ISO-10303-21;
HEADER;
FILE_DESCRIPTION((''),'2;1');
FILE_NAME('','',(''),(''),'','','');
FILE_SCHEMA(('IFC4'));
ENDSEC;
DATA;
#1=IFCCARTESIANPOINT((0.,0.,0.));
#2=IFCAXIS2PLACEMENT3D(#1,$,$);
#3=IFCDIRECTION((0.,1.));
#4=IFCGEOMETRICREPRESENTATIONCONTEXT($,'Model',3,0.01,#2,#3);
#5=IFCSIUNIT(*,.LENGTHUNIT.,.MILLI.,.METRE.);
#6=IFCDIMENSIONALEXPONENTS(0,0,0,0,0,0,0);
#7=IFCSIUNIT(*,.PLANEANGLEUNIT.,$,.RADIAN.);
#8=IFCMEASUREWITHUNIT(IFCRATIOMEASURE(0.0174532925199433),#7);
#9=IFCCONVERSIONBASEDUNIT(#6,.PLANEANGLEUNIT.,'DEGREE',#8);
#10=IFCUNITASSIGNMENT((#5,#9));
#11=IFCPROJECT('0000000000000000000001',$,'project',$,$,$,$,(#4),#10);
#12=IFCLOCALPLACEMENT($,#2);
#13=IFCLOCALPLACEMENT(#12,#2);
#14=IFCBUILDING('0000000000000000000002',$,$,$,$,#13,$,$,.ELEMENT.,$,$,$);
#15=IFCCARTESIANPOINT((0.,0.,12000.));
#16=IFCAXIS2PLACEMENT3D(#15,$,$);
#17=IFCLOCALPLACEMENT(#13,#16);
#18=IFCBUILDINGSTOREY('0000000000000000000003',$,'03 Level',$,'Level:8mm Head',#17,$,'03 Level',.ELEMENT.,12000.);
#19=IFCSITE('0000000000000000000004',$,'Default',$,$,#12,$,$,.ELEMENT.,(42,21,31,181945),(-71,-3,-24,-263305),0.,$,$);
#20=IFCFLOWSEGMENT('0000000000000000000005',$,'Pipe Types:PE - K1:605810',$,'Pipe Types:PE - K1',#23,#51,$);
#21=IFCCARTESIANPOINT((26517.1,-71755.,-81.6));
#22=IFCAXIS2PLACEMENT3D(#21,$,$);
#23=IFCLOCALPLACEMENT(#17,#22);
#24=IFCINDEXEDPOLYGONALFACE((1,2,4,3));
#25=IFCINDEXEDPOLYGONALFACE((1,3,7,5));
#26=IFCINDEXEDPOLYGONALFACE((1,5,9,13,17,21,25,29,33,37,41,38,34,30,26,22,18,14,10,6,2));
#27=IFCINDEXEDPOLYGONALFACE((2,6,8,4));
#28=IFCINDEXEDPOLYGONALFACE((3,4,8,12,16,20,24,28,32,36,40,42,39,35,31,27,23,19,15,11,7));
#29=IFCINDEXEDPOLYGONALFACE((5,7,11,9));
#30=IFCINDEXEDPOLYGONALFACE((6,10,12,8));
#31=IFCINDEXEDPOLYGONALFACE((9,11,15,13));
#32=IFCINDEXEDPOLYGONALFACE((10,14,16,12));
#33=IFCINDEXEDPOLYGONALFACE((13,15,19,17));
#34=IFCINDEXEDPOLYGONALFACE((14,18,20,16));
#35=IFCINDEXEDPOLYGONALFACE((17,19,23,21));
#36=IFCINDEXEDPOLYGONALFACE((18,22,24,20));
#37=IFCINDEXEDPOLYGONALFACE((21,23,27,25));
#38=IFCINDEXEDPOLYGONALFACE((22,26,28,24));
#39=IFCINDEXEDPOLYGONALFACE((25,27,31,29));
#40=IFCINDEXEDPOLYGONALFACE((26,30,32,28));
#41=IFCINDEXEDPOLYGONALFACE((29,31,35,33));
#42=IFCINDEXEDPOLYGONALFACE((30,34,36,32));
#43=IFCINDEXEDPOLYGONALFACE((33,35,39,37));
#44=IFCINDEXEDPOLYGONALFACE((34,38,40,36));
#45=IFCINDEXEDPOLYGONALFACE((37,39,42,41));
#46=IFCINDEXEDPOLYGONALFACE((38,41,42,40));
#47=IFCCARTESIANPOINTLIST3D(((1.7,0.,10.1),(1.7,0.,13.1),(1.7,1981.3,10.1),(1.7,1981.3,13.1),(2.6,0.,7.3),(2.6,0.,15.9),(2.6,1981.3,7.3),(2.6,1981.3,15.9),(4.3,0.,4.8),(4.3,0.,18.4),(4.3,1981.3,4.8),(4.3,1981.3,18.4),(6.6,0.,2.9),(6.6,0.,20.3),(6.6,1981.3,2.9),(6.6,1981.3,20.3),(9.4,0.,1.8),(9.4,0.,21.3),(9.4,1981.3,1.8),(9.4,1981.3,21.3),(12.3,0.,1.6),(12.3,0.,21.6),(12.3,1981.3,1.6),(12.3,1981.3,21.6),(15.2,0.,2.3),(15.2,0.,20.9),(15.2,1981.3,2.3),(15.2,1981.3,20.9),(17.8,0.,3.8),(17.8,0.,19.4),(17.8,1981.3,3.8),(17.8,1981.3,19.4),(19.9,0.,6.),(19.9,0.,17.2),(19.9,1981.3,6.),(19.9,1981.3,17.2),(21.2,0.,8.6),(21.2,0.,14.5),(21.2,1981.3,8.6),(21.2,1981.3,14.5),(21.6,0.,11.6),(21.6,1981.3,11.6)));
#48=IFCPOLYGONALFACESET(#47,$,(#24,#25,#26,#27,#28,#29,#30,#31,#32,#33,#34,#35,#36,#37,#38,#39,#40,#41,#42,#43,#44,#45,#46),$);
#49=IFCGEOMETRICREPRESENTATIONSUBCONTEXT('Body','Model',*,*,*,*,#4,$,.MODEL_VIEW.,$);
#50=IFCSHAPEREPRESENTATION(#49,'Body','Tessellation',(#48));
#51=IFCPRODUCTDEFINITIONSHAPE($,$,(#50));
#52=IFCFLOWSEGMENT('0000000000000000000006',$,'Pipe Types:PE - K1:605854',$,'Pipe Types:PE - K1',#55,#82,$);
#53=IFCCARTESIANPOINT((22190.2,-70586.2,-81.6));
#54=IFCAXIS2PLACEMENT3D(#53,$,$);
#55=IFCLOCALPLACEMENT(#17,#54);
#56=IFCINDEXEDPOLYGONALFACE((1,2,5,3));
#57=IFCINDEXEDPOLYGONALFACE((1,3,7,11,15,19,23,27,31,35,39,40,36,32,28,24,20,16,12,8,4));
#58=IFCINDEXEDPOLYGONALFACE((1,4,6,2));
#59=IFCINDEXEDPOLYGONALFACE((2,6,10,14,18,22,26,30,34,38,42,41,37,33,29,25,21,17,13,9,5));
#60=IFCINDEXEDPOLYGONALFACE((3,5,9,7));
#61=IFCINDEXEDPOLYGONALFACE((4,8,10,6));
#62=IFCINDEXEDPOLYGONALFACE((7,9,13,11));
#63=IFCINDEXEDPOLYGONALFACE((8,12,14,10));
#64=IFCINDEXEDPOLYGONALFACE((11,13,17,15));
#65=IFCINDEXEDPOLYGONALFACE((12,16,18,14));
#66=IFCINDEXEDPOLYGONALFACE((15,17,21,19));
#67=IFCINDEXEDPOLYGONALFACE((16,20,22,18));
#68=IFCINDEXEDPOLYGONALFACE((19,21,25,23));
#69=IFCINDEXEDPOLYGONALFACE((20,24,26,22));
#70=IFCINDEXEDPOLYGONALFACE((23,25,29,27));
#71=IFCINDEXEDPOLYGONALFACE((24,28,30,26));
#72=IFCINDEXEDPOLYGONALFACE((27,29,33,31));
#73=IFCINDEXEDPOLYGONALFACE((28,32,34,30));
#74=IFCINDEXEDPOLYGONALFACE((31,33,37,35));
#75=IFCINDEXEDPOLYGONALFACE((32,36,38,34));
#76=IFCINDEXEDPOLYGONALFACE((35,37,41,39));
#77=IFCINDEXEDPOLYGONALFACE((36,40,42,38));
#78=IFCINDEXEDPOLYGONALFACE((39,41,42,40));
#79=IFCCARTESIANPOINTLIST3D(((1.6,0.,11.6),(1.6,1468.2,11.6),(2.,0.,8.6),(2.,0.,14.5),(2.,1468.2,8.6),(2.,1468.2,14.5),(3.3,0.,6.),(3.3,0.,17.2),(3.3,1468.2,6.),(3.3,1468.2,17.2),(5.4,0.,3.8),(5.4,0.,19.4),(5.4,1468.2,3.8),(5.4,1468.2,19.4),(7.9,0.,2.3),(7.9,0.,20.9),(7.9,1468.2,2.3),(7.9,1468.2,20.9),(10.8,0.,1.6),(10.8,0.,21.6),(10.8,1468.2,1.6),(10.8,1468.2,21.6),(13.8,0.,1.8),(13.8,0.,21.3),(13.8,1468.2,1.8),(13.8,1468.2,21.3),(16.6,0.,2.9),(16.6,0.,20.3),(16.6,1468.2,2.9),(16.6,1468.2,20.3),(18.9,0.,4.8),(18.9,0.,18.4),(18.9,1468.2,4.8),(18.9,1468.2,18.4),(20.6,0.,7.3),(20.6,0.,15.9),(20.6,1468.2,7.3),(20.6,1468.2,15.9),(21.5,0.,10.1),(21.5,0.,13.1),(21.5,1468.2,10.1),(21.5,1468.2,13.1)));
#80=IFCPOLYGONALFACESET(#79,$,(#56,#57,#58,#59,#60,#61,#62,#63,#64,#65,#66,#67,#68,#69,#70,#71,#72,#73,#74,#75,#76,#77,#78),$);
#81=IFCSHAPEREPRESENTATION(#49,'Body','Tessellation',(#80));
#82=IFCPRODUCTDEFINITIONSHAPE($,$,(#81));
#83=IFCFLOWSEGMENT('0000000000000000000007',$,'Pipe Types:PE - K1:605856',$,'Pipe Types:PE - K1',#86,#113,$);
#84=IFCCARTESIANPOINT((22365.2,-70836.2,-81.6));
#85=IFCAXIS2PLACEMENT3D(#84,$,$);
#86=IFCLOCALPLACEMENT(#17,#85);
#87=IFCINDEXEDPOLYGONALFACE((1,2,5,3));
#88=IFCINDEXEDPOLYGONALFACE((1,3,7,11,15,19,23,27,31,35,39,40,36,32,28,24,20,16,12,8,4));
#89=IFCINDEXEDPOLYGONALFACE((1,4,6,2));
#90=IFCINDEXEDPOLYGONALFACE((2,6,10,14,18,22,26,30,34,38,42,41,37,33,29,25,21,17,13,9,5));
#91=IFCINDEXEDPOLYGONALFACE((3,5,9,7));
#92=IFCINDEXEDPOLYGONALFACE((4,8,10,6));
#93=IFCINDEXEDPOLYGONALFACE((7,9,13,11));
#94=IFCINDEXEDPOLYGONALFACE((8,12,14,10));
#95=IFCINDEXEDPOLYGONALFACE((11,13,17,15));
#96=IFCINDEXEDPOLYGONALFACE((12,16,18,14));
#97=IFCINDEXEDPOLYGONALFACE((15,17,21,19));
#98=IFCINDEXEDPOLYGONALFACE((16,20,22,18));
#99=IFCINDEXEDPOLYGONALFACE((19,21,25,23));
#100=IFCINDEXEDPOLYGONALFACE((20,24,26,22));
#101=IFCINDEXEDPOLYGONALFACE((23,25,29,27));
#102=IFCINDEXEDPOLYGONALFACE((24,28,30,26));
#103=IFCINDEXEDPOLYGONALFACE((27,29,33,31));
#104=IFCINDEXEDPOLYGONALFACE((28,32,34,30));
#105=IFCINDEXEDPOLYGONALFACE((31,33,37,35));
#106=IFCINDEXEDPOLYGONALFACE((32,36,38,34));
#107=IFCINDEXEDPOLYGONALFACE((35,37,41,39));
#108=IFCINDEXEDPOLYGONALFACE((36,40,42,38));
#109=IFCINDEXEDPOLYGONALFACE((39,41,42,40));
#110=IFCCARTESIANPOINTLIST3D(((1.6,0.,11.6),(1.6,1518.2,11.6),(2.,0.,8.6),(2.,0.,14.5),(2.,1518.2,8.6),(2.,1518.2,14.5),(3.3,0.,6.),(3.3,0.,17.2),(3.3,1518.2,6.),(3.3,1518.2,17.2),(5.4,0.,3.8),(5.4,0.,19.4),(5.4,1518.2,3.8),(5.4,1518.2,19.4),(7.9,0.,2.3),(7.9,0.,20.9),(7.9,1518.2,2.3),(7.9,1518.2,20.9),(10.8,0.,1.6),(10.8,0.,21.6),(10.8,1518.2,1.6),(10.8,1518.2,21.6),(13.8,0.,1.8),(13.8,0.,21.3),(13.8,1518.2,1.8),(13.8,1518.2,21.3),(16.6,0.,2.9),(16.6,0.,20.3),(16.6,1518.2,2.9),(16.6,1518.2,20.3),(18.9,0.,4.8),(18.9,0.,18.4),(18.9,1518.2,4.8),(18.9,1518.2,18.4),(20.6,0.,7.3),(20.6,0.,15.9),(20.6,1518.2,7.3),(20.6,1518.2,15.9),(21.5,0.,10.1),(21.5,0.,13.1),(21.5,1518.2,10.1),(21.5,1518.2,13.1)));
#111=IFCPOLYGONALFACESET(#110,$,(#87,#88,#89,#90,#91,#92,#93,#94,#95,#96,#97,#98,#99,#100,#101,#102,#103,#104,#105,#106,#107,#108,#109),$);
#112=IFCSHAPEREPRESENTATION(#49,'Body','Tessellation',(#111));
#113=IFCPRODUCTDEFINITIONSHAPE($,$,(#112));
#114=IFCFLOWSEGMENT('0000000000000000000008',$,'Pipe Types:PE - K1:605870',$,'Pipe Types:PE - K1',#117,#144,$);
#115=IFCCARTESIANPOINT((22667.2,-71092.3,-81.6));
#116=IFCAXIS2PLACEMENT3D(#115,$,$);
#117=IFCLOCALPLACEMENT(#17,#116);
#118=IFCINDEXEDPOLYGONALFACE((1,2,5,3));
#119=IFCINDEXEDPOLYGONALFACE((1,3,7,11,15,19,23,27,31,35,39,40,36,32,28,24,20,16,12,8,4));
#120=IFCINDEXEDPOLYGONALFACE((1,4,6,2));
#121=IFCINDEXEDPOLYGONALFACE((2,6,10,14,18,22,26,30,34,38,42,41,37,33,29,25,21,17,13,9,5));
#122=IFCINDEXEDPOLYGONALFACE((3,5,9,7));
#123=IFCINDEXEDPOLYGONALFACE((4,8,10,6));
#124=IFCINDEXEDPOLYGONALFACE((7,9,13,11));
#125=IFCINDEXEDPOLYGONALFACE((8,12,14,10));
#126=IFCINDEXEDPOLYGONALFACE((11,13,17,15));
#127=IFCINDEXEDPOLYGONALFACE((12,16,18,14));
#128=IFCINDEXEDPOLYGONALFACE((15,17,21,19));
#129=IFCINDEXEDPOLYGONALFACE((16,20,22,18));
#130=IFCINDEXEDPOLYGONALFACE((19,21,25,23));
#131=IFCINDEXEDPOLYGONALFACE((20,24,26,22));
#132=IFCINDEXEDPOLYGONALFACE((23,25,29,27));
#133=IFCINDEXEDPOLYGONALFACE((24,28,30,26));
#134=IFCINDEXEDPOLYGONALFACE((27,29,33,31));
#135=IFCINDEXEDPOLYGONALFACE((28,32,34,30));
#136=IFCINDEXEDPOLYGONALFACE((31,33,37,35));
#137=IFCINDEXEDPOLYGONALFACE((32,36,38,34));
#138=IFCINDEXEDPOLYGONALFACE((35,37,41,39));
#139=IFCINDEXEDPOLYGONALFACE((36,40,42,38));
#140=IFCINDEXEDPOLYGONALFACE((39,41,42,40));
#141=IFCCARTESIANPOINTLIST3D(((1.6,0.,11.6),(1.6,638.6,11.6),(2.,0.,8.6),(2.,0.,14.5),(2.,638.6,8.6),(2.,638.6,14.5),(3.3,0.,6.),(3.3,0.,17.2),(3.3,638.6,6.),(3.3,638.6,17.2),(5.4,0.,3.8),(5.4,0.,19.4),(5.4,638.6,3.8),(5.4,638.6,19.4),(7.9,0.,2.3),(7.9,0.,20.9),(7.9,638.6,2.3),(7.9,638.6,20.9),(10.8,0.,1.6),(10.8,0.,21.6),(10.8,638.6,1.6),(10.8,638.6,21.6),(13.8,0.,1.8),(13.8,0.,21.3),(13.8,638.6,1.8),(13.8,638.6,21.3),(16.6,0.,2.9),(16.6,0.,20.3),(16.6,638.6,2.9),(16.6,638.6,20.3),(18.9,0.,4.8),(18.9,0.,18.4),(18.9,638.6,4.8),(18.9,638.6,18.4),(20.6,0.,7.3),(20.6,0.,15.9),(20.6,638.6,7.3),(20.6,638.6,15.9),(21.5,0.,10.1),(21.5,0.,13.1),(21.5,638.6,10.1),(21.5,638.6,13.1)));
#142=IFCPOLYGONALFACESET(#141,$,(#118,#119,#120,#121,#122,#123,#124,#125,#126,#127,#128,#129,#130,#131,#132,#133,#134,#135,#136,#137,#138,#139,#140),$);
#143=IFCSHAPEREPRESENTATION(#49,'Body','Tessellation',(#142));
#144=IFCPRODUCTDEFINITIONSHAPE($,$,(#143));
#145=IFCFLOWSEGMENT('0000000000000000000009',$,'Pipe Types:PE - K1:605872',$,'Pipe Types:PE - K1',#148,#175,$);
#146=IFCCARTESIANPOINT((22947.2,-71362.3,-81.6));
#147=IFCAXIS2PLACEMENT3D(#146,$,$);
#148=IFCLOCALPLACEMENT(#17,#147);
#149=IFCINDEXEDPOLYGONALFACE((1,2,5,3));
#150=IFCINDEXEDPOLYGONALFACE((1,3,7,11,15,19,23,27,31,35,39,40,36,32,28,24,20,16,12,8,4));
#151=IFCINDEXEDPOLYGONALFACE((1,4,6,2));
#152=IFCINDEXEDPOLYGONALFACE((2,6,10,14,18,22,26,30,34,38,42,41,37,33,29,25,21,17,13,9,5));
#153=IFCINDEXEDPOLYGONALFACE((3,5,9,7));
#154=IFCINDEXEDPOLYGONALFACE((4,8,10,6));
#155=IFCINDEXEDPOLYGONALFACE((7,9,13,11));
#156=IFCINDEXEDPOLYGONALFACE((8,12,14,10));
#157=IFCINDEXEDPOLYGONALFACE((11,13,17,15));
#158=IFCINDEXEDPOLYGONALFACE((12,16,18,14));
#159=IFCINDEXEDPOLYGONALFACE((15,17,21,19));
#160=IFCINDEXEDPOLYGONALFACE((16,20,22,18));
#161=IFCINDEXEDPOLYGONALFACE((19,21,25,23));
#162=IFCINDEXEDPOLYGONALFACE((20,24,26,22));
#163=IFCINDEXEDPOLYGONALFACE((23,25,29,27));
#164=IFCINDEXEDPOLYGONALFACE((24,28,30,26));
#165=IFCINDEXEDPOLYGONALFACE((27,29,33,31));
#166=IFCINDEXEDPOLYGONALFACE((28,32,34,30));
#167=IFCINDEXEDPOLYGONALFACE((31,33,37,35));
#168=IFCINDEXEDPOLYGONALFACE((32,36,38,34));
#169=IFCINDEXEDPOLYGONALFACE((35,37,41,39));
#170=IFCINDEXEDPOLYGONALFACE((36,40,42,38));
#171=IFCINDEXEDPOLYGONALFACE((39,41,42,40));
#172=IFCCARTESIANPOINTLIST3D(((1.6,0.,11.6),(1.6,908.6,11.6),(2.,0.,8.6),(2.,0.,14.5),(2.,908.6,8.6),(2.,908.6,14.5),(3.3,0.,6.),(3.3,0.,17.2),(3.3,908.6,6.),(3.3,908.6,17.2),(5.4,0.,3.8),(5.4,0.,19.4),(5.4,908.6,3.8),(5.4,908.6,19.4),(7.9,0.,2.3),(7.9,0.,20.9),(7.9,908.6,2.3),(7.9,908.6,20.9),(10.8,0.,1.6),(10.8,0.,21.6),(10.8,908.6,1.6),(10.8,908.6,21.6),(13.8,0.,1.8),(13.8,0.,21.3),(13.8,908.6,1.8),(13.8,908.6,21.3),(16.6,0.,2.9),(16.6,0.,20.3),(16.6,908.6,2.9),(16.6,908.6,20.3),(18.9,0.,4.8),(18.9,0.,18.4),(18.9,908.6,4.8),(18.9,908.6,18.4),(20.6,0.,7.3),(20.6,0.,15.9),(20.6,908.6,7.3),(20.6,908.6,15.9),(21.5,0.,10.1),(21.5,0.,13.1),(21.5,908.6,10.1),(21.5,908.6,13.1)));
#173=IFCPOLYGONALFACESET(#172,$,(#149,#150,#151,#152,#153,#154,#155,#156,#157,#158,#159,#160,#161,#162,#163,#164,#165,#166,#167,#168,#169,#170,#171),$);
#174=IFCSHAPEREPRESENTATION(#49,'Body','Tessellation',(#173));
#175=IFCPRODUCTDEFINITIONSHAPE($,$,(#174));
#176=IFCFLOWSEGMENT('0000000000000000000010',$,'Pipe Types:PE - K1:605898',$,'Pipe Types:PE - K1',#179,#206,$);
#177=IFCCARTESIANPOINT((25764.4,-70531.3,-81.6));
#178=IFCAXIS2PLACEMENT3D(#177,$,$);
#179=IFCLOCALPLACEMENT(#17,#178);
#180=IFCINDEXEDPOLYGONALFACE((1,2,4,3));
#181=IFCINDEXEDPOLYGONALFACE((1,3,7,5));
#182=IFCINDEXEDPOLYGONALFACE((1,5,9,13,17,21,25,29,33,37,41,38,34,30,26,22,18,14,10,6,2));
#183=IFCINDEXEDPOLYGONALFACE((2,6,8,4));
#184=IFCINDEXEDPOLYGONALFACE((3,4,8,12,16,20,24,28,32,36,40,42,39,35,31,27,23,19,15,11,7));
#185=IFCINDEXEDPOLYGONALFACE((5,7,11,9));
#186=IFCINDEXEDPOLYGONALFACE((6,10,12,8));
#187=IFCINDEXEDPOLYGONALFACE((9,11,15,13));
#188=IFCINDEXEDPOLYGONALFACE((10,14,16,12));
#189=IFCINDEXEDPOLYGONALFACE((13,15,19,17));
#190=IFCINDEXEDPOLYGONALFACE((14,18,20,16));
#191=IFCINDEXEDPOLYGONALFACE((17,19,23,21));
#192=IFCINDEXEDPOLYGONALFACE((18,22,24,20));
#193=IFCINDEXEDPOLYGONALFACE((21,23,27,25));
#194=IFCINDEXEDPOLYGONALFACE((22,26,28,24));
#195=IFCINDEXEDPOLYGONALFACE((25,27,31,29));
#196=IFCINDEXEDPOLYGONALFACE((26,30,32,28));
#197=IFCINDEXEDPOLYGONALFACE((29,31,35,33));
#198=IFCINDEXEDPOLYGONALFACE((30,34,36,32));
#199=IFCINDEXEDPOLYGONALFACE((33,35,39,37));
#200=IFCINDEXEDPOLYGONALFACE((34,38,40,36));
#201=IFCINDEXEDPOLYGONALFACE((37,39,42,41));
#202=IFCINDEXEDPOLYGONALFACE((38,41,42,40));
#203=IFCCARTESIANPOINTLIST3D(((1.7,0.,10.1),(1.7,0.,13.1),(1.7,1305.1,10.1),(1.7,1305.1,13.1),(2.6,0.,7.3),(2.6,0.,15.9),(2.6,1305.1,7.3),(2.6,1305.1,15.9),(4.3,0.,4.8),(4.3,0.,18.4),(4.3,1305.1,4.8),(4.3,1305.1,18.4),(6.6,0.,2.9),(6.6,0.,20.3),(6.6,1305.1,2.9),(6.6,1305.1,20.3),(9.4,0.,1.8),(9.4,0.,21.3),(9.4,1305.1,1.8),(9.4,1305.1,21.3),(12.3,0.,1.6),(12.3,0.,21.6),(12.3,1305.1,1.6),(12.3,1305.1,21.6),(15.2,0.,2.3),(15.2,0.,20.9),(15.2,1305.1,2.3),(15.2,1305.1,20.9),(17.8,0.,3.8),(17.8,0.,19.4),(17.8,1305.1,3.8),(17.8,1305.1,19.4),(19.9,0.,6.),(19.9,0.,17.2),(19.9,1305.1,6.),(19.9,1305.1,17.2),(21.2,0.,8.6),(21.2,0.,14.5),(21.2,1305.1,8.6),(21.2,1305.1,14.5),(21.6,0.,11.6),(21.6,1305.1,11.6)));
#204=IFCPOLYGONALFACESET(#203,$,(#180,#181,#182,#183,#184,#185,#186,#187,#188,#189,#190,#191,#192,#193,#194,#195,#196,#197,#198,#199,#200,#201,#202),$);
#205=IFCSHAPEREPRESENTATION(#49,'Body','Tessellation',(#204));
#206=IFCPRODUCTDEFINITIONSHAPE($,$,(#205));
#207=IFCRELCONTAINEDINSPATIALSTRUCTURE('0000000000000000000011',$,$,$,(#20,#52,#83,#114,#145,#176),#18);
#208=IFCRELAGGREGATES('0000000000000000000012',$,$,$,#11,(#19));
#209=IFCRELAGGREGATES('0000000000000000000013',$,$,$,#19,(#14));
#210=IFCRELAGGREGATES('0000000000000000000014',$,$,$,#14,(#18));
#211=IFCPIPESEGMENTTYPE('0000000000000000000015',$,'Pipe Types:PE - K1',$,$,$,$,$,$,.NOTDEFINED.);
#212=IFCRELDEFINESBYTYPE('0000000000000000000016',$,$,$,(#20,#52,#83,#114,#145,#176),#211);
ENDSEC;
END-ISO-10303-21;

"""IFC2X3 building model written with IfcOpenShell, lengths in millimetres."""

from ifc_helpers import new_model, entity, si_unit, converted_unit, direction, frame, frame_2d, origin, origin_2d_with_axis, place, context, subcontext, project, spatial, circle, extrude, type_object, element, save


model = new_model("IFC2X3")

# Units and contexts
model_context = context("Model", 3, precision=0.01, world=origin(), true_north=direction((0.0, 1.0)))
body_context = subcontext(model_context, "Body", "Model", "MODEL_VIEW")
ifc_project = project(units=[si_unit("LENGTHUNIT", "METRE", prefix="MILLI"), converted_unit("PLANEANGLEUNIT", "DEGREE", entity("IfcRatioMeasure", 0.0174532925199433), si_unit("PLANEANGLEUNIT", "RADIAN"), dimensions=[0, 0, 0, 0, 0, 0, 0])], contexts=[model_context])

# Site, building, storey
site_placement = place(None, origin())
site = spatial("IfcSite", under=ifc_project, at=site_placement, Name="Default", CompositionType="ELEMENT", RefLatitude=(42, 21, 31, 181945), RefLongitude=(-71, -3, -24, -263305), RefElevation=0.0)
building_placement = place(site_placement, origin())
building = spatial("IfcBuilding", under=site, at=building_placement, CompositionType="ELEMENT")
storey_placement = place(building_placement, frame((0.0, 0.0, 12000.0)))
storey = spatial("IfcBuildingStorey", under=building, at=storey_placement, Name="03 Level", ObjectType="Level:8mm Head", LongName="03 Level", CompositionType="ELEMENT", Elevation=12000.0)

# Flow segments
pipe_segment_type = type_object("IfcPipeSegmentType", Name="Pipe Types:PE - K1", PredefinedType="NOTDEFINED")
flow_segment_1_placement = place(storey_placement, frame((26517.1, -71755.0, -81.6)))
element("IfcFlowSegment", 1, at=flow_segment_1_placement, inside=storey, type_object=pipe_segment_type, Name="Pipe Types:PE - K1:605810", ObjectType="Pipe Types:PE - K1", context=body_context, shape_type="SweptSolid", body=[
    extrude(circle(Radius=10.0, at=origin_2d_with_axis()), frame((11.6, 0.0, 11.6), z_axis=(0.0, 1.0, 0.0), x_axis=(1.0, 0.0, 0.0)), (0.0, 0.0, 1.0), 1981.3),
])
flow_segment_2_placement = place(storey_placement, frame((22190.2, -70586.2, -81.6)))
element("IfcFlowSegment", 2, at=flow_segment_2_placement, inside=storey, type_object=pipe_segment_type, Name="Pipe Types:PE - K1:605854", ObjectType="Pipe Types:PE - K1", context=body_context, shape_type="SweptSolid", body=[
    extrude(circle(Radius=10.0, at=frame_2d((0.0, 0.0), x_axis=(1.0, 0.0))), frame((11.6, 0.0, 11.6), z_axis=(0.0, 1.0, 0.0), x_axis=(-1.0, 0.0, 0.0)), (0.0, 0.0, 1.0), 1468.2),
])
flow_segment_3_placement = place(storey_placement, frame((22365.2, -70836.2, -81.6)))
element("IfcFlowSegment", 3, at=flow_segment_3_placement, inside=storey, type_object=pipe_segment_type, Name="Pipe Types:PE - K1:605856", ObjectType="Pipe Types:PE - K1", context=body_context, shape_type="SweptSolid", body=[
    extrude(circle(Radius=10.0, at=frame_2d((0.0, 0.0), x_axis=(1.0, 0.0))), frame((11.6, 0.0, 11.6), z_axis=(0.0, 1.0, 0.0), x_axis=(-1.0, 0.0, 0.0)), (0.0, 0.0, 1.0), 1518.2),
])
flow_segment_4_placement = place(storey_placement, frame((22667.2, -71092.3, -81.6)))
element("IfcFlowSegment", 4, at=flow_segment_4_placement, inside=storey, type_object=pipe_segment_type, Name="Pipe Types:PE - K1:605870", ObjectType="Pipe Types:PE - K1", context=body_context, shape_type="SweptSolid", body=[
    extrude(circle(Radius=10.0, at=frame_2d((0.0, 0.0), x_axis=(1.0, 0.0))), frame((11.6, 0.0, 11.6), z_axis=(0.0, 1.0, 0.0), x_axis=(-1.0, 0.0, 0.0)), (0.0, 0.0, 1.0), 638.6),
])
flow_segment_5_placement = place(storey_placement, frame((22947.2, -71362.3, -81.6)))
element("IfcFlowSegment", 5, at=flow_segment_5_placement, inside=storey, type_object=pipe_segment_type, Name="Pipe Types:PE - K1:605872", ObjectType="Pipe Types:PE - K1", context=body_context, shape_type="SweptSolid", body=[
    extrude(circle(Radius=10.0, at=frame_2d((0.0, 0.0), x_axis=(1.0, 0.0))), frame((11.6, 0.0, 11.6), z_axis=(0.0, 1.0, 0.0), x_axis=(-1.0, 0.0, 0.0)), (0.0, 0.0, 1.0), 908.6),
])
flow_segment_6_placement = place(storey_placement, frame((25764.4, -70531.3, -81.6)))
element("IfcFlowSegment", 6, at=flow_segment_6_placement, inside=storey, type_object=pipe_segment_type, Name="Pipe Types:PE - K1:605898", ObjectType="Pipe Types:PE - K1", context=body_context, shape_type="SweptSolid", body=[
    extrude(circle(Radius=10.0, at=origin_2d_with_axis()), frame((11.6, 0.0, 11.6), z_axis=(0.0, 1.0, 0.0), x_axis=(1.0, 0.0, 0.0)), (0.0, 0.0, 1.0), 1305.1),
])

save(model, "model.ifc")
